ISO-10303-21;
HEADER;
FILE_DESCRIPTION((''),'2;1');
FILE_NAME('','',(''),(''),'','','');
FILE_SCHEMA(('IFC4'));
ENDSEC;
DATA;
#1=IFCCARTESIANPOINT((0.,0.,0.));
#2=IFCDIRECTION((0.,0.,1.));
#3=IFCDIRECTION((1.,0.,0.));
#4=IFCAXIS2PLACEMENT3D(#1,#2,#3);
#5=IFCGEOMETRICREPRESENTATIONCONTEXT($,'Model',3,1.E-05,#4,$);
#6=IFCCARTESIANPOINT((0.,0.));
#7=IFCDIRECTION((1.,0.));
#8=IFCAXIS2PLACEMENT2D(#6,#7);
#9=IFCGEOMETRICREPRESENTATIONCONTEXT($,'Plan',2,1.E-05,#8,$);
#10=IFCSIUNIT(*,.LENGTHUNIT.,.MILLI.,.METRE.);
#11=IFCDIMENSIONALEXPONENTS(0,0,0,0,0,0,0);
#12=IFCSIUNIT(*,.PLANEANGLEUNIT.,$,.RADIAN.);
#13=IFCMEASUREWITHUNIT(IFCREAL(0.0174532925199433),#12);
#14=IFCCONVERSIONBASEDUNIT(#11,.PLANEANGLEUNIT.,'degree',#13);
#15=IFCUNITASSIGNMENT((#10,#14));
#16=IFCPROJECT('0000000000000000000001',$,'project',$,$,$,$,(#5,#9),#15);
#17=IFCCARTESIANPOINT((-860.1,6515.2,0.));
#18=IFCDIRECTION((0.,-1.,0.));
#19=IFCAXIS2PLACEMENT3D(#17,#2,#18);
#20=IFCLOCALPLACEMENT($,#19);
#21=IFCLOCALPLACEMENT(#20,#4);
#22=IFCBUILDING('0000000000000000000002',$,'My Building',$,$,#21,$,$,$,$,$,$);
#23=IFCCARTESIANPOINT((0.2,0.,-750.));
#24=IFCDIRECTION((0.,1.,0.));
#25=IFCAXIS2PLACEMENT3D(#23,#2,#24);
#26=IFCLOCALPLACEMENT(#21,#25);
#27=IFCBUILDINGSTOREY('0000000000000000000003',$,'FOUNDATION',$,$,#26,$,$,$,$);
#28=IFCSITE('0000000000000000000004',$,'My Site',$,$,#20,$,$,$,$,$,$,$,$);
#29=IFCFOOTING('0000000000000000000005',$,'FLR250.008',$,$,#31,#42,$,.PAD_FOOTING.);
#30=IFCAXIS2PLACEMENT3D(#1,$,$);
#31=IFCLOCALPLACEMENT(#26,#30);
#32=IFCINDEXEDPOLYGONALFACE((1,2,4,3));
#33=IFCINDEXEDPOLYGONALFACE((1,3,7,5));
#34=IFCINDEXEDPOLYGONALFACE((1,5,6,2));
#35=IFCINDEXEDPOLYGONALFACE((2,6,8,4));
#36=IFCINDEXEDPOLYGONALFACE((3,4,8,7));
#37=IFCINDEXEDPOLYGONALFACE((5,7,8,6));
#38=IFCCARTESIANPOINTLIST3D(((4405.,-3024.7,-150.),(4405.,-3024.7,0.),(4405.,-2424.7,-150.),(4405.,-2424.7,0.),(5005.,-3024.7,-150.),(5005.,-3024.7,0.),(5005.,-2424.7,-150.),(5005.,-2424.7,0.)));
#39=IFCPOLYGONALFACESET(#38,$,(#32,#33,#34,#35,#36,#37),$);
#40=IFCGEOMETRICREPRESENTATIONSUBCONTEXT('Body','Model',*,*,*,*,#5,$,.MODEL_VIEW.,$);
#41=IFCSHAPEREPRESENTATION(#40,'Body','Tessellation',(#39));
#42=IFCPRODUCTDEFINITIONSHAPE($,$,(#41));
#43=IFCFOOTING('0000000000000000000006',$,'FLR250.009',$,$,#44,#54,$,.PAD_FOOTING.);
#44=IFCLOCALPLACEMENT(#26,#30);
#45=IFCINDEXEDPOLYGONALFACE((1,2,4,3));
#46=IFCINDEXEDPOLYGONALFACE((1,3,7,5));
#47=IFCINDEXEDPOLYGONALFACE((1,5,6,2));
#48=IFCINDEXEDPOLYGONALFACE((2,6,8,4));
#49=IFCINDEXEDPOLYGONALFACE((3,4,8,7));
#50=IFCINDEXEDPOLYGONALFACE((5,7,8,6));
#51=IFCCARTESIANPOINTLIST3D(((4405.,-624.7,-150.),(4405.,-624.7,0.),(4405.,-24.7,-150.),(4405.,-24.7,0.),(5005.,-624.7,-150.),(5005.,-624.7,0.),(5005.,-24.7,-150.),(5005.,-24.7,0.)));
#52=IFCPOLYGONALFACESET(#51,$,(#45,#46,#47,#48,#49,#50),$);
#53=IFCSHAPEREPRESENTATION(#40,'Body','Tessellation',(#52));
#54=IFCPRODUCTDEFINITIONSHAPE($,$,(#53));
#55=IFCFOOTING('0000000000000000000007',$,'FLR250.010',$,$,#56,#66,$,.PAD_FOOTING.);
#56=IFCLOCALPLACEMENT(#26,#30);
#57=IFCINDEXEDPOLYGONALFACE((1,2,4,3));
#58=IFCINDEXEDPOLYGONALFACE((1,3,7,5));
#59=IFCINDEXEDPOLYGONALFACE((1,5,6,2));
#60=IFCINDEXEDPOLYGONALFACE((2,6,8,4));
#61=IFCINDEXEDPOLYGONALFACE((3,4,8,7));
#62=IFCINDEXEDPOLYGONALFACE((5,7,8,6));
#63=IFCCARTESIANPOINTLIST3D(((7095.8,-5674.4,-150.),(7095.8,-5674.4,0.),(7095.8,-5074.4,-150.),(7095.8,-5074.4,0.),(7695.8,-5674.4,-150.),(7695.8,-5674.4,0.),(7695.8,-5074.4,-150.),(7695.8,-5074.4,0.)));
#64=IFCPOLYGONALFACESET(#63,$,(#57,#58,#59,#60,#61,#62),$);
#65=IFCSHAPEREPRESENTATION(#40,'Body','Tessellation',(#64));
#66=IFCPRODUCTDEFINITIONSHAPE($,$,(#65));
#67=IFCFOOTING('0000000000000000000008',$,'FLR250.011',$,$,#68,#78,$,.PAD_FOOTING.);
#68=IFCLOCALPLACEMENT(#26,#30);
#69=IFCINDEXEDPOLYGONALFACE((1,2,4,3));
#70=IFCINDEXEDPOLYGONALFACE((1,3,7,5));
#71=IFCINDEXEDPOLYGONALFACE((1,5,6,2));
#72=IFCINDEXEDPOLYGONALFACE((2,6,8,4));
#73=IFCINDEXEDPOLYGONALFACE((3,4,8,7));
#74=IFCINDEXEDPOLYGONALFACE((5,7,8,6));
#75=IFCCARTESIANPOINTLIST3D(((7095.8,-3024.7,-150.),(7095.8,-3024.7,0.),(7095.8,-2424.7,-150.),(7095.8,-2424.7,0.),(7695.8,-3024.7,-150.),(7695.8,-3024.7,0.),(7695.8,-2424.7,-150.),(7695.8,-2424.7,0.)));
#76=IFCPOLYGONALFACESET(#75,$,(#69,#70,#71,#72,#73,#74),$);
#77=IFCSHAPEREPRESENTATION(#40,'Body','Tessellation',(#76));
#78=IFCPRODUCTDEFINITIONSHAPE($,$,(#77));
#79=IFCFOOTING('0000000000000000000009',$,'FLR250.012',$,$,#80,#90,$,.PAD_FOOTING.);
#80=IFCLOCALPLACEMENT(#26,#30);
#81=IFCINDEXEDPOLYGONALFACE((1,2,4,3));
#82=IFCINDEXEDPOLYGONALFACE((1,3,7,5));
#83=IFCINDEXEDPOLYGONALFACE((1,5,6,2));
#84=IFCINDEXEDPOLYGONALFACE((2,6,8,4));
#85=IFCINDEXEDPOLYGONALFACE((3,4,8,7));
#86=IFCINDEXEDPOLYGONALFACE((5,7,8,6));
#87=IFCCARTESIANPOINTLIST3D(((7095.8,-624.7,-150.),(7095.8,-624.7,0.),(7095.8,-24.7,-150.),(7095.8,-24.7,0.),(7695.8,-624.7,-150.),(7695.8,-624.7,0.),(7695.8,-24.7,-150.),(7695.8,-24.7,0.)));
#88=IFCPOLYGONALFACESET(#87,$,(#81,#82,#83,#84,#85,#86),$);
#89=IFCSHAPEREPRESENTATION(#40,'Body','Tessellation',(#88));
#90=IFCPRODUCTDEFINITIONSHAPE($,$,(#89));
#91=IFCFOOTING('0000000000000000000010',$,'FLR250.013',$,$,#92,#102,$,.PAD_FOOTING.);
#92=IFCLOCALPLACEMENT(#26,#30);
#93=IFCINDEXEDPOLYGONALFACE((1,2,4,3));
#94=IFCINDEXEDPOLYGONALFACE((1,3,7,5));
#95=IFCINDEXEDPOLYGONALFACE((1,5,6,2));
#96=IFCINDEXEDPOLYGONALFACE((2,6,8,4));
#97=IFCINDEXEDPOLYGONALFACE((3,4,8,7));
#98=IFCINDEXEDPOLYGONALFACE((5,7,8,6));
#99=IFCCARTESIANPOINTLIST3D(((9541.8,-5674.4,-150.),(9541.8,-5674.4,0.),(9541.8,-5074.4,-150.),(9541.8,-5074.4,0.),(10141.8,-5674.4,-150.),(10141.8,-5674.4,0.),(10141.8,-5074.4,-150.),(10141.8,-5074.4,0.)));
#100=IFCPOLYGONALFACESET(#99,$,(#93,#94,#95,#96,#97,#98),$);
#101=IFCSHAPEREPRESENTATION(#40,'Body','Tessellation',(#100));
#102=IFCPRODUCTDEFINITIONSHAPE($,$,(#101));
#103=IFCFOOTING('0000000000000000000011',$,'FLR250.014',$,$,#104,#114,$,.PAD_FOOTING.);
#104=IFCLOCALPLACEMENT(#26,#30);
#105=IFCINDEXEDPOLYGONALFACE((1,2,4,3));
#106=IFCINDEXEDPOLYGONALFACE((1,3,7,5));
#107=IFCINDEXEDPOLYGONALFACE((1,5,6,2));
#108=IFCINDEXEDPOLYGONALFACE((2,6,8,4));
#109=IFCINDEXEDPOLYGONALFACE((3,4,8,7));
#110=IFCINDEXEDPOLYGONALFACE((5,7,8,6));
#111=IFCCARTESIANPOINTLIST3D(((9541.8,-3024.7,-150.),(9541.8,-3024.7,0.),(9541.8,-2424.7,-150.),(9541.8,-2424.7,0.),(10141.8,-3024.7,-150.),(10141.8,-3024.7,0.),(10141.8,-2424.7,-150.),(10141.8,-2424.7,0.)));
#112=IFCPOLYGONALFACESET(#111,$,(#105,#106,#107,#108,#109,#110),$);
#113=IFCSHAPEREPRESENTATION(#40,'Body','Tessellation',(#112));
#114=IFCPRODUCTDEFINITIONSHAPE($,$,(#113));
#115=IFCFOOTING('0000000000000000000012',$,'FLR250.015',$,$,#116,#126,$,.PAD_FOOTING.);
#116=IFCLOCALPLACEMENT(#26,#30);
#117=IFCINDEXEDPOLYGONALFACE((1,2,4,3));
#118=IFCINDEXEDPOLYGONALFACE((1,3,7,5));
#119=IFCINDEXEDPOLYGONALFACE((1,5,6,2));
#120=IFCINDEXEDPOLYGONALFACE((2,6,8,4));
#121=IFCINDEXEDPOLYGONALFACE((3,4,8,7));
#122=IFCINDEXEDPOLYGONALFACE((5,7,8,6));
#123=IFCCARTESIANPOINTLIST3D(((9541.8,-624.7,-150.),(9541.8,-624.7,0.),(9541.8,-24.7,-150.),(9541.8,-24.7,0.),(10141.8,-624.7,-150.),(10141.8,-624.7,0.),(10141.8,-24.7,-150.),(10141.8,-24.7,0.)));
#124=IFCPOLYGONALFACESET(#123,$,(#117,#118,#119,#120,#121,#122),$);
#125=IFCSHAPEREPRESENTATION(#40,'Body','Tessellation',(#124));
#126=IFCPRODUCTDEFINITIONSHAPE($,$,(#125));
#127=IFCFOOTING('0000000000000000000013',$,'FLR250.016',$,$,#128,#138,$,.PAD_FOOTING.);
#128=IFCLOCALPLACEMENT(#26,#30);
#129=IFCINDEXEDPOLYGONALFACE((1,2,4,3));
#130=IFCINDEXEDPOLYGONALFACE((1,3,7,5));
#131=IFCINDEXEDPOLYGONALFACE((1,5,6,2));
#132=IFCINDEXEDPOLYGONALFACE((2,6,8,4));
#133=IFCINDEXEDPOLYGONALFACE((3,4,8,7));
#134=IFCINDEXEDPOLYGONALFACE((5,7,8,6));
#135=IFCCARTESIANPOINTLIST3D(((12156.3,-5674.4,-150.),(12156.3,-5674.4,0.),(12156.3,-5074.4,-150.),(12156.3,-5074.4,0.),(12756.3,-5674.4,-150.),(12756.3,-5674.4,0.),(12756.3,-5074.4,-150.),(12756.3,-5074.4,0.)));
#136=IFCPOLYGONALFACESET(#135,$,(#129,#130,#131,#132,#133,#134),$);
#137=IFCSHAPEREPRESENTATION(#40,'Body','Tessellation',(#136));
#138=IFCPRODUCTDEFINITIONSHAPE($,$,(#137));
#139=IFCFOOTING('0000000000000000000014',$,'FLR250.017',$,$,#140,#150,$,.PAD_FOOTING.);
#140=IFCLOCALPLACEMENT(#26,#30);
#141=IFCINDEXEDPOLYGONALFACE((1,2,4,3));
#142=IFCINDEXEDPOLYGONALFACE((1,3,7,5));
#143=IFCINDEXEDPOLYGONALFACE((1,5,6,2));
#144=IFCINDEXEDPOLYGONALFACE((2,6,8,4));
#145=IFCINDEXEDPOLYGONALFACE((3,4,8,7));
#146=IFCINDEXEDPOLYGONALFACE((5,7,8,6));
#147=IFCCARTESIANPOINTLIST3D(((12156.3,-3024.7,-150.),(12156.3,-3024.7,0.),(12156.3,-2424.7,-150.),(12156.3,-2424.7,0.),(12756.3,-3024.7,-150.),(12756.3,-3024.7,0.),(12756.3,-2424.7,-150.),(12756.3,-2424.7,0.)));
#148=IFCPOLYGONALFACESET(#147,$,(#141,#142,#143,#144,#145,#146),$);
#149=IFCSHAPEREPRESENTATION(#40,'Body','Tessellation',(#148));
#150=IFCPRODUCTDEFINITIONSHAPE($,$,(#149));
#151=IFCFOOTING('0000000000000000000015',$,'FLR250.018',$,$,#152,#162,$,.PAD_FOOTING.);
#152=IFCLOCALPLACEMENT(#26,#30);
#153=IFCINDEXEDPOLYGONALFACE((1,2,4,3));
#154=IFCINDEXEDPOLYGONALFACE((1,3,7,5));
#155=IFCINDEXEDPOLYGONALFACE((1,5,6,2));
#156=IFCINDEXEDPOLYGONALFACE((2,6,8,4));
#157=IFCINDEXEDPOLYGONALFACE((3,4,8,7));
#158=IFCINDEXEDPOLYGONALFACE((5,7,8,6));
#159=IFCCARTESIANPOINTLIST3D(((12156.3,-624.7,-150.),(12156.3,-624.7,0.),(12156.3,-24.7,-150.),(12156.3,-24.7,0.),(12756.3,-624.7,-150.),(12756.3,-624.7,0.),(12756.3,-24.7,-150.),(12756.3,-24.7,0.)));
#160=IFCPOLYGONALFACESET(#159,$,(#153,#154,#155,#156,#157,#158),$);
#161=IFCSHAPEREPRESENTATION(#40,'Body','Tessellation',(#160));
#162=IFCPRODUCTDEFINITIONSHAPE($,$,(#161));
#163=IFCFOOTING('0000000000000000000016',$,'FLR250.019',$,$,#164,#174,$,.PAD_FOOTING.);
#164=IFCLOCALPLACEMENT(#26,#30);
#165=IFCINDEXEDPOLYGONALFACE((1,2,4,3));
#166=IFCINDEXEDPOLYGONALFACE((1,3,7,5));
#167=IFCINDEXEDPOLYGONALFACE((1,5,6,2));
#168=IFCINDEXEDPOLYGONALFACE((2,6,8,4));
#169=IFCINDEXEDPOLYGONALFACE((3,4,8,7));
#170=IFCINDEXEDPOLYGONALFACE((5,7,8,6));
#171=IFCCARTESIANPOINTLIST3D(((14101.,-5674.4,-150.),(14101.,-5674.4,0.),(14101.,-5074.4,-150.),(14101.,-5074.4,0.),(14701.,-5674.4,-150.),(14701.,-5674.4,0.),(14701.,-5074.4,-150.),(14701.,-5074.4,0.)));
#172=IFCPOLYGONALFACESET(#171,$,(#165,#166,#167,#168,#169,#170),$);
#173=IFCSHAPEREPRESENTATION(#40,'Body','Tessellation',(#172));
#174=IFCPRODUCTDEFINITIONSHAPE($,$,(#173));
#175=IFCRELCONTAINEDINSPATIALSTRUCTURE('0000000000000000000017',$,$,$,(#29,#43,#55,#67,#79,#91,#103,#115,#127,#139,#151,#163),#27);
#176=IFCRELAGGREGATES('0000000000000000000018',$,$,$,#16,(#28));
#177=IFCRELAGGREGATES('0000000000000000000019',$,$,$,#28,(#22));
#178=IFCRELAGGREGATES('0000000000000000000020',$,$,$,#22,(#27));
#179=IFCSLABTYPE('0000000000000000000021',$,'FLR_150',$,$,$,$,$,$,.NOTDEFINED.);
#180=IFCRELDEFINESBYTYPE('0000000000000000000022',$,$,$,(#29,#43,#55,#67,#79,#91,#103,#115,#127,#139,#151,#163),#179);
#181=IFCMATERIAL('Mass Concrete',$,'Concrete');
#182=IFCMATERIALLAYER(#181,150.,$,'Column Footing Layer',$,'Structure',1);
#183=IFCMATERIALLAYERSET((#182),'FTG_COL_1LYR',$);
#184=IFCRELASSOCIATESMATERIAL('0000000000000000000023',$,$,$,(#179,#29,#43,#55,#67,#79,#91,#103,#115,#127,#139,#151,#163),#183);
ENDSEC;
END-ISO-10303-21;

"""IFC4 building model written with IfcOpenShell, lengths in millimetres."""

from ifc_helpers import new_model, entity, si_unit, converted_unit, frame, origin_with_axes, origin_2d_with_axis, place, context, subcontext, project, spatial, line, indexed_curve, outline, extrude, material, layer, layer_set, layer_usage, type_object, element, save


model = new_model("IFC4")

# Units and contexts
model_context = context("Model", 3, precision=1e-05, world=origin_with_axes())
plan_context = context("Plan", 2, precision=1e-05, world=origin_2d_with_axis())
body_context = subcontext(model_context, "Body", "Model", "MODEL_VIEW")
ifc_project = project(units=[si_unit("LENGTHUNIT", "METRE", prefix="MILLI"), converted_unit("PLANEANGLEUNIT", "degree", entity("IfcReal", 0.0174532925199433), si_unit("PLANEANGLEUNIT", "RADIAN"), dimensions=[0, 0, 0, 0, 0, 0, 0])], contexts=[model_context, plan_context])

# Site, building, storey
site_placement = place(None, frame((-860.1, 6515.2, 0.0), z_axis=(0.0, 0.0, 1.0), x_axis=(0.0, -1.0, 0.0)))
site = spatial("IfcSite", under=ifc_project, at=site_placement, Name="My Site")
building_placement = place(site_placement, frame((0.0, 0.0, 0.0), z_axis=(0.0, 0.0, 1.0), x_axis=(1.0, 0.0, 0.0)))
building = spatial("IfcBuilding", under=site, at=building_placement, Name="My Building")
storey_placement = place(building_placement, frame((0.2, 0.0, -750.0), z_axis=(0.0, 0.0, 1.0), x_axis=(0.0, 1.0, 0.0)))
storey = spatial("IfcBuildingStorey", under=building, at=storey_placement, Name="FOUNDATION")

# Footings
ifc_material_1 = material(Name="Mass Concrete", Category="Concrete")
ifc_layer_1 = layer(ifc_material_1, 150.0, Name="Column Footing Layer", Category="Structure", Priority=1)
ifc_layer_set_1 = layer_set([ifc_layer_1], Name="FTG_COL_1LYR")
ifc_layer_usage_1 = layer_usage(ifc_layer_set_1, "AXIS3", "POSITIVE", 0.0)
slab_type = type_object("IfcSlabType", Name="FLR_150", PredefinedType="NOTDEFINED", material=ifc_layer_set_1)
footing_1_placement = place(storey_placement, frame((4405.0, -3024.7, -150.0), z_axis=(0.0, 0.0, 1.0), x_axis=(1.0, 0.0, 0.0)))
element("IfcFooting", 1, at=footing_1_placement, inside=storey, type_object=slab_type, material=ifc_layer_usage_1, Name="FLR250.008", PredefinedType="PAD_FOOTING", context=body_context, shape_type="SweptSolid", body=[
    extrude(outline(indexed_curve([(0.0, 0.0), (600.0, 0.0), (600.0, 600.0), (0.0, 600.0)], segments=[line(3, 2), line(2, 1), line(1, 4), line(4, 3)], self_intersect=False)), None, (0.0, 0.0, 1.0), 150.0),
])
ifc_layer_usage_2 = layer_usage(ifc_layer_set_1, "AXIS3", "POSITIVE", 0.0)
footing_2_placement = place(storey_placement, frame((4405.0, -624.7, -150.0), z_axis=(0.0, 0.0, 1.0), x_axis=(1.0, 0.0, 0.0)))
element("IfcFooting", 2, at=footing_2_placement, inside=storey, type_object=slab_type, material=ifc_layer_usage_2, Name="FLR250.009", PredefinedType="PAD_FOOTING", context=body_context, shape_type="SweptSolid", body=[
    extrude(outline(indexed_curve([(0.0, 0.0), (600.0, 0.0), (600.0, 600.0), (0.0, 600.0)], segments=[line(3, 2), line(2, 1), line(1, 4), line(4, 3)], self_intersect=False)), None, (0.0, 0.0, 1.0), 150.0),
])
ifc_layer_usage_3 = layer_usage(ifc_layer_set_1, "AXIS3", "POSITIVE", 0.0)
footing_3_placement = place(storey_placement, frame((7095.8, -5674.4, -150.0), z_axis=(0.0, 0.0, 1.0), x_axis=(1.0, 0.0, 0.0)))
element("IfcFooting", 3, at=footing_3_placement, inside=storey, type_object=slab_type, material=ifc_layer_usage_3, Name="FLR250.010", PredefinedType="PAD_FOOTING", context=body_context, shape_type="SweptSolid", body=[
    extrude(outline(indexed_curve([(0.0, 0.0), (600.0, 0.0), (600.0, 600.0), (0.0, 600.0)], segments=[line(3, 2), line(2, 1), line(1, 4), line(4, 3)], self_intersect=False)), None, (0.0, 0.0, 1.0), 150.0),
])
ifc_layer_usage_4 = layer_usage(ifc_layer_set_1, "AXIS3", "POSITIVE", 0.0)
footing_4_placement = place(storey_placement, frame((7095.8, -3024.7, -150.0), z_axis=(0.0, 0.0, 1.0), x_axis=(1.0, 0.0, 0.0)))
element("IfcFooting", 4, at=footing_4_placement, inside=storey, type_object=slab_type, material=ifc_layer_usage_4, Name="FLR250.011", PredefinedType="PAD_FOOTING", context=body_context, shape_type="SweptSolid", body=[
    extrude(outline(indexed_curve([(0.0, 0.0), (600.0, 0.0), (600.0, 600.0), (0.0, 600.0)], segments=[line(3, 2), line(2, 1), line(1, 4), line(4, 3)], self_intersect=False)), None, (0.0, 0.0, 1.0), 150.0),
])
ifc_layer_usage_5 = layer_usage(ifc_layer_set_1, "AXIS3", "POSITIVE", 0.0)
footing_5_placement = place(storey_placement, frame((7095.8, -624.7, -150.0), z_axis=(0.0, 0.0, 1.0), x_axis=(1.0, 0.0, 0.0)))
element("IfcFooting", 5, at=footing_5_placement, inside=storey, type_object=slab_type, material=ifc_layer_usage_5, Name="FLR250.012", PredefinedType="PAD_FOOTING", context=body_context, shape_type="SweptSolid", body=[
    extrude(outline(indexed_curve([(0.0, 0.0), (600.0, 0.0), (600.0, 600.0), (0.0, 600.0)], segments=[line(3, 2), line(2, 1), line(1, 4), line(4, 3)], self_intersect=False)), None, (0.0, 0.0, 1.0), 150.0),
])
ifc_layer_usage_6 = layer_usage(ifc_layer_set_1, "AXIS3", "POSITIVE", 0.0)
footing_6_placement = place(storey_placement, frame((9541.8, -5674.4, -150.0), z_axis=(0.0, 0.0, 1.0), x_axis=(1.0, 0.0, 0.0)))
element("IfcFooting", 6, at=footing_6_placement, inside=storey, type_object=slab_type, material=ifc_layer_usage_6, Name="FLR250.013", PredefinedType="PAD_FOOTING", context=body_context, shape_type="SweptSolid", body=[
    extrude(outline(indexed_curve([(0.0, 0.0), (600.0, 0.0), (600.0, 600.0), (0.0, 600.0)], segments=[line(3, 2), line(2, 1), line(1, 4), line(4, 3)], self_intersect=False)), None, (0.0, 0.0, 1.0), 150.0),
])
ifc_layer_usage_7 = layer_usage(ifc_layer_set_1, "AXIS3", "POSITIVE", 0.0)
footing_7_placement = place(storey_placement, frame((9541.8, -3024.7, -150.0), z_axis=(0.0, 0.0, 1.0), x_axis=(1.0, 0.0, 0.0)))
element("IfcFooting", 7, at=footing_7_placement, inside=storey, type_object=slab_type, material=ifc_layer_usage_7, Name="FLR250.014", PredefinedType="PAD_FOOTING", context=body_context, shape_type="SweptSolid", body=[
    extrude(outline(indexed_curve([(0.0, 0.0), (600.0, 0.0), (600.0, 600.0), (0.0, 600.0)], segments=[line(3, 2), line(2, 1), line(1, 4), line(4, 3)], self_intersect=False)), None, (0.0, 0.0, 1.0), 150.0),
])
ifc_layer_usage_8 = layer_usage(ifc_layer_set_1, "AXIS3", "POSITIVE", 0.0)
footing_8_placement = place(storey_placement, frame((9541.8, -624.7, -150.0), z_axis=(0.0, 0.0, 1.0), x_axis=(1.0, 0.0, 0.0)))
element("IfcFooting", 8, at=footing_8_placement, inside=storey, type_object=slab_type, material=ifc_layer_usage_8, Name="FLR250.015", PredefinedType="PAD_FOOTING", context=body_context, shape_type="SweptSolid", body=[
    extrude(outline(indexed_curve([(0.0, 0.0), (600.0, 0.0), (600.0, 600.0), (0.0, 600.0)], segments=[line(3, 2), line(2, 1), line(1, 4), line(4, 3)], self_intersect=False)), None, (0.0, 0.0, 1.0), 150.0),
])
ifc_layer_usage_9 = layer_usage(ifc_layer_set_1, "AXIS3", "POSITIVE", 0.0)
footing_9_placement = place(storey_placement, frame((12156.3, -5674.4, -150.0), z_axis=(0.0, 0.0, 1.0), x_axis=(1.0, 0.0, 0.0)))
element("IfcFooting", 9, at=footing_9_placement, inside=storey, type_object=slab_type, material=ifc_layer_usage_9, Name="FLR250.016", PredefinedType="PAD_FOOTING", context=body_context, shape_type="SweptSolid", body=[
    extrude(outline(indexed_curve([(0.0, 0.0), (600.0, 0.0), (600.0, 600.0), (0.0, 600.0)], segments=[line(3, 2), line(2, 1), line(1, 4), line(4, 3)], self_intersect=False)), None, (0.0, 0.0, 1.0), 150.0),
])
ifc_layer_usage_10 = layer_usage(ifc_layer_set_1, "AXIS3", "POSITIVE", 0.0)
footing_10_placement = place(storey_placement, frame((12156.3, -3024.7, -150.0), z_axis=(0.0, 0.0, 1.0), x_axis=(1.0, 0.0, 0.0)))
element("IfcFooting", 10, at=footing_10_placement, inside=storey, type_object=slab_type, material=ifc_layer_usage_10, Name="FLR250.017", PredefinedType="PAD_FOOTING", context=body_context, shape_type="SweptSolid", body=[
    extrude(outline(indexed_curve([(0.0, 0.0), (600.0, 0.0), (600.0, 600.0), (0.0, 600.0)], segments=[line(3, 2), line(2, 1), line(1, 4), line(4, 3)], self_intersect=False)), None, (0.0, 0.0, 1.0), 150.0),
])
ifc_layer_usage_11 = layer_usage(ifc_layer_set_1, "AXIS3", "POSITIVE", 0.0)
footing_11_placement = place(storey_placement, frame((12156.3, -624.7, -150.0), z_axis=(0.0, 0.0, 1.0), x_axis=(1.0, 0.0, 0.0)))
element("IfcFooting", 11, at=footing_11_placement, inside=storey, type_object=slab_type, material=ifc_layer_usage_11, Name="FLR250.018", PredefinedType="PAD_FOOTING", context=body_context, shape_type="SweptSolid", body=[
    extrude(outline(indexed_curve([(0.0, 0.0), (600.0, 0.0), (600.0, 600.0), (0.0, 600.0)], segments=[line(3, 2), line(2, 1), line(1, 4), line(4, 3)], self_intersect=False)), None, (0.0, 0.0, 1.0), 150.0),
])
ifc_layer_usage_12 = layer_usage(ifc_layer_set_1, "AXIS3", "POSITIVE", 0.0)
footing_12_placement = place(storey_placement, frame((14101.0, -5674.4, -150.0), z_axis=(0.0, 0.0, 1.0), x_axis=(1.0, 0.0, 0.0)))
element("IfcFooting", 12, at=footing_12_placement, inside=storey, type_object=slab_type, material=ifc_layer_usage_12, Name="FLR250.019", PredefinedType="PAD_FOOTING", context=body_context, shape_type="SweptSolid", body=[
    extrude(outline(indexed_curve([(0.0, 0.0), (600.0, 0.0), (600.0, 600.0), (0.0, 600.0)], segments=[line(3, 2), line(2, 1), line(1, 4), line(4, 3)], self_intersect=False)), None, (0.0, 0.0, 1.0), 150.0),
])

save(model, "model.ifc")
